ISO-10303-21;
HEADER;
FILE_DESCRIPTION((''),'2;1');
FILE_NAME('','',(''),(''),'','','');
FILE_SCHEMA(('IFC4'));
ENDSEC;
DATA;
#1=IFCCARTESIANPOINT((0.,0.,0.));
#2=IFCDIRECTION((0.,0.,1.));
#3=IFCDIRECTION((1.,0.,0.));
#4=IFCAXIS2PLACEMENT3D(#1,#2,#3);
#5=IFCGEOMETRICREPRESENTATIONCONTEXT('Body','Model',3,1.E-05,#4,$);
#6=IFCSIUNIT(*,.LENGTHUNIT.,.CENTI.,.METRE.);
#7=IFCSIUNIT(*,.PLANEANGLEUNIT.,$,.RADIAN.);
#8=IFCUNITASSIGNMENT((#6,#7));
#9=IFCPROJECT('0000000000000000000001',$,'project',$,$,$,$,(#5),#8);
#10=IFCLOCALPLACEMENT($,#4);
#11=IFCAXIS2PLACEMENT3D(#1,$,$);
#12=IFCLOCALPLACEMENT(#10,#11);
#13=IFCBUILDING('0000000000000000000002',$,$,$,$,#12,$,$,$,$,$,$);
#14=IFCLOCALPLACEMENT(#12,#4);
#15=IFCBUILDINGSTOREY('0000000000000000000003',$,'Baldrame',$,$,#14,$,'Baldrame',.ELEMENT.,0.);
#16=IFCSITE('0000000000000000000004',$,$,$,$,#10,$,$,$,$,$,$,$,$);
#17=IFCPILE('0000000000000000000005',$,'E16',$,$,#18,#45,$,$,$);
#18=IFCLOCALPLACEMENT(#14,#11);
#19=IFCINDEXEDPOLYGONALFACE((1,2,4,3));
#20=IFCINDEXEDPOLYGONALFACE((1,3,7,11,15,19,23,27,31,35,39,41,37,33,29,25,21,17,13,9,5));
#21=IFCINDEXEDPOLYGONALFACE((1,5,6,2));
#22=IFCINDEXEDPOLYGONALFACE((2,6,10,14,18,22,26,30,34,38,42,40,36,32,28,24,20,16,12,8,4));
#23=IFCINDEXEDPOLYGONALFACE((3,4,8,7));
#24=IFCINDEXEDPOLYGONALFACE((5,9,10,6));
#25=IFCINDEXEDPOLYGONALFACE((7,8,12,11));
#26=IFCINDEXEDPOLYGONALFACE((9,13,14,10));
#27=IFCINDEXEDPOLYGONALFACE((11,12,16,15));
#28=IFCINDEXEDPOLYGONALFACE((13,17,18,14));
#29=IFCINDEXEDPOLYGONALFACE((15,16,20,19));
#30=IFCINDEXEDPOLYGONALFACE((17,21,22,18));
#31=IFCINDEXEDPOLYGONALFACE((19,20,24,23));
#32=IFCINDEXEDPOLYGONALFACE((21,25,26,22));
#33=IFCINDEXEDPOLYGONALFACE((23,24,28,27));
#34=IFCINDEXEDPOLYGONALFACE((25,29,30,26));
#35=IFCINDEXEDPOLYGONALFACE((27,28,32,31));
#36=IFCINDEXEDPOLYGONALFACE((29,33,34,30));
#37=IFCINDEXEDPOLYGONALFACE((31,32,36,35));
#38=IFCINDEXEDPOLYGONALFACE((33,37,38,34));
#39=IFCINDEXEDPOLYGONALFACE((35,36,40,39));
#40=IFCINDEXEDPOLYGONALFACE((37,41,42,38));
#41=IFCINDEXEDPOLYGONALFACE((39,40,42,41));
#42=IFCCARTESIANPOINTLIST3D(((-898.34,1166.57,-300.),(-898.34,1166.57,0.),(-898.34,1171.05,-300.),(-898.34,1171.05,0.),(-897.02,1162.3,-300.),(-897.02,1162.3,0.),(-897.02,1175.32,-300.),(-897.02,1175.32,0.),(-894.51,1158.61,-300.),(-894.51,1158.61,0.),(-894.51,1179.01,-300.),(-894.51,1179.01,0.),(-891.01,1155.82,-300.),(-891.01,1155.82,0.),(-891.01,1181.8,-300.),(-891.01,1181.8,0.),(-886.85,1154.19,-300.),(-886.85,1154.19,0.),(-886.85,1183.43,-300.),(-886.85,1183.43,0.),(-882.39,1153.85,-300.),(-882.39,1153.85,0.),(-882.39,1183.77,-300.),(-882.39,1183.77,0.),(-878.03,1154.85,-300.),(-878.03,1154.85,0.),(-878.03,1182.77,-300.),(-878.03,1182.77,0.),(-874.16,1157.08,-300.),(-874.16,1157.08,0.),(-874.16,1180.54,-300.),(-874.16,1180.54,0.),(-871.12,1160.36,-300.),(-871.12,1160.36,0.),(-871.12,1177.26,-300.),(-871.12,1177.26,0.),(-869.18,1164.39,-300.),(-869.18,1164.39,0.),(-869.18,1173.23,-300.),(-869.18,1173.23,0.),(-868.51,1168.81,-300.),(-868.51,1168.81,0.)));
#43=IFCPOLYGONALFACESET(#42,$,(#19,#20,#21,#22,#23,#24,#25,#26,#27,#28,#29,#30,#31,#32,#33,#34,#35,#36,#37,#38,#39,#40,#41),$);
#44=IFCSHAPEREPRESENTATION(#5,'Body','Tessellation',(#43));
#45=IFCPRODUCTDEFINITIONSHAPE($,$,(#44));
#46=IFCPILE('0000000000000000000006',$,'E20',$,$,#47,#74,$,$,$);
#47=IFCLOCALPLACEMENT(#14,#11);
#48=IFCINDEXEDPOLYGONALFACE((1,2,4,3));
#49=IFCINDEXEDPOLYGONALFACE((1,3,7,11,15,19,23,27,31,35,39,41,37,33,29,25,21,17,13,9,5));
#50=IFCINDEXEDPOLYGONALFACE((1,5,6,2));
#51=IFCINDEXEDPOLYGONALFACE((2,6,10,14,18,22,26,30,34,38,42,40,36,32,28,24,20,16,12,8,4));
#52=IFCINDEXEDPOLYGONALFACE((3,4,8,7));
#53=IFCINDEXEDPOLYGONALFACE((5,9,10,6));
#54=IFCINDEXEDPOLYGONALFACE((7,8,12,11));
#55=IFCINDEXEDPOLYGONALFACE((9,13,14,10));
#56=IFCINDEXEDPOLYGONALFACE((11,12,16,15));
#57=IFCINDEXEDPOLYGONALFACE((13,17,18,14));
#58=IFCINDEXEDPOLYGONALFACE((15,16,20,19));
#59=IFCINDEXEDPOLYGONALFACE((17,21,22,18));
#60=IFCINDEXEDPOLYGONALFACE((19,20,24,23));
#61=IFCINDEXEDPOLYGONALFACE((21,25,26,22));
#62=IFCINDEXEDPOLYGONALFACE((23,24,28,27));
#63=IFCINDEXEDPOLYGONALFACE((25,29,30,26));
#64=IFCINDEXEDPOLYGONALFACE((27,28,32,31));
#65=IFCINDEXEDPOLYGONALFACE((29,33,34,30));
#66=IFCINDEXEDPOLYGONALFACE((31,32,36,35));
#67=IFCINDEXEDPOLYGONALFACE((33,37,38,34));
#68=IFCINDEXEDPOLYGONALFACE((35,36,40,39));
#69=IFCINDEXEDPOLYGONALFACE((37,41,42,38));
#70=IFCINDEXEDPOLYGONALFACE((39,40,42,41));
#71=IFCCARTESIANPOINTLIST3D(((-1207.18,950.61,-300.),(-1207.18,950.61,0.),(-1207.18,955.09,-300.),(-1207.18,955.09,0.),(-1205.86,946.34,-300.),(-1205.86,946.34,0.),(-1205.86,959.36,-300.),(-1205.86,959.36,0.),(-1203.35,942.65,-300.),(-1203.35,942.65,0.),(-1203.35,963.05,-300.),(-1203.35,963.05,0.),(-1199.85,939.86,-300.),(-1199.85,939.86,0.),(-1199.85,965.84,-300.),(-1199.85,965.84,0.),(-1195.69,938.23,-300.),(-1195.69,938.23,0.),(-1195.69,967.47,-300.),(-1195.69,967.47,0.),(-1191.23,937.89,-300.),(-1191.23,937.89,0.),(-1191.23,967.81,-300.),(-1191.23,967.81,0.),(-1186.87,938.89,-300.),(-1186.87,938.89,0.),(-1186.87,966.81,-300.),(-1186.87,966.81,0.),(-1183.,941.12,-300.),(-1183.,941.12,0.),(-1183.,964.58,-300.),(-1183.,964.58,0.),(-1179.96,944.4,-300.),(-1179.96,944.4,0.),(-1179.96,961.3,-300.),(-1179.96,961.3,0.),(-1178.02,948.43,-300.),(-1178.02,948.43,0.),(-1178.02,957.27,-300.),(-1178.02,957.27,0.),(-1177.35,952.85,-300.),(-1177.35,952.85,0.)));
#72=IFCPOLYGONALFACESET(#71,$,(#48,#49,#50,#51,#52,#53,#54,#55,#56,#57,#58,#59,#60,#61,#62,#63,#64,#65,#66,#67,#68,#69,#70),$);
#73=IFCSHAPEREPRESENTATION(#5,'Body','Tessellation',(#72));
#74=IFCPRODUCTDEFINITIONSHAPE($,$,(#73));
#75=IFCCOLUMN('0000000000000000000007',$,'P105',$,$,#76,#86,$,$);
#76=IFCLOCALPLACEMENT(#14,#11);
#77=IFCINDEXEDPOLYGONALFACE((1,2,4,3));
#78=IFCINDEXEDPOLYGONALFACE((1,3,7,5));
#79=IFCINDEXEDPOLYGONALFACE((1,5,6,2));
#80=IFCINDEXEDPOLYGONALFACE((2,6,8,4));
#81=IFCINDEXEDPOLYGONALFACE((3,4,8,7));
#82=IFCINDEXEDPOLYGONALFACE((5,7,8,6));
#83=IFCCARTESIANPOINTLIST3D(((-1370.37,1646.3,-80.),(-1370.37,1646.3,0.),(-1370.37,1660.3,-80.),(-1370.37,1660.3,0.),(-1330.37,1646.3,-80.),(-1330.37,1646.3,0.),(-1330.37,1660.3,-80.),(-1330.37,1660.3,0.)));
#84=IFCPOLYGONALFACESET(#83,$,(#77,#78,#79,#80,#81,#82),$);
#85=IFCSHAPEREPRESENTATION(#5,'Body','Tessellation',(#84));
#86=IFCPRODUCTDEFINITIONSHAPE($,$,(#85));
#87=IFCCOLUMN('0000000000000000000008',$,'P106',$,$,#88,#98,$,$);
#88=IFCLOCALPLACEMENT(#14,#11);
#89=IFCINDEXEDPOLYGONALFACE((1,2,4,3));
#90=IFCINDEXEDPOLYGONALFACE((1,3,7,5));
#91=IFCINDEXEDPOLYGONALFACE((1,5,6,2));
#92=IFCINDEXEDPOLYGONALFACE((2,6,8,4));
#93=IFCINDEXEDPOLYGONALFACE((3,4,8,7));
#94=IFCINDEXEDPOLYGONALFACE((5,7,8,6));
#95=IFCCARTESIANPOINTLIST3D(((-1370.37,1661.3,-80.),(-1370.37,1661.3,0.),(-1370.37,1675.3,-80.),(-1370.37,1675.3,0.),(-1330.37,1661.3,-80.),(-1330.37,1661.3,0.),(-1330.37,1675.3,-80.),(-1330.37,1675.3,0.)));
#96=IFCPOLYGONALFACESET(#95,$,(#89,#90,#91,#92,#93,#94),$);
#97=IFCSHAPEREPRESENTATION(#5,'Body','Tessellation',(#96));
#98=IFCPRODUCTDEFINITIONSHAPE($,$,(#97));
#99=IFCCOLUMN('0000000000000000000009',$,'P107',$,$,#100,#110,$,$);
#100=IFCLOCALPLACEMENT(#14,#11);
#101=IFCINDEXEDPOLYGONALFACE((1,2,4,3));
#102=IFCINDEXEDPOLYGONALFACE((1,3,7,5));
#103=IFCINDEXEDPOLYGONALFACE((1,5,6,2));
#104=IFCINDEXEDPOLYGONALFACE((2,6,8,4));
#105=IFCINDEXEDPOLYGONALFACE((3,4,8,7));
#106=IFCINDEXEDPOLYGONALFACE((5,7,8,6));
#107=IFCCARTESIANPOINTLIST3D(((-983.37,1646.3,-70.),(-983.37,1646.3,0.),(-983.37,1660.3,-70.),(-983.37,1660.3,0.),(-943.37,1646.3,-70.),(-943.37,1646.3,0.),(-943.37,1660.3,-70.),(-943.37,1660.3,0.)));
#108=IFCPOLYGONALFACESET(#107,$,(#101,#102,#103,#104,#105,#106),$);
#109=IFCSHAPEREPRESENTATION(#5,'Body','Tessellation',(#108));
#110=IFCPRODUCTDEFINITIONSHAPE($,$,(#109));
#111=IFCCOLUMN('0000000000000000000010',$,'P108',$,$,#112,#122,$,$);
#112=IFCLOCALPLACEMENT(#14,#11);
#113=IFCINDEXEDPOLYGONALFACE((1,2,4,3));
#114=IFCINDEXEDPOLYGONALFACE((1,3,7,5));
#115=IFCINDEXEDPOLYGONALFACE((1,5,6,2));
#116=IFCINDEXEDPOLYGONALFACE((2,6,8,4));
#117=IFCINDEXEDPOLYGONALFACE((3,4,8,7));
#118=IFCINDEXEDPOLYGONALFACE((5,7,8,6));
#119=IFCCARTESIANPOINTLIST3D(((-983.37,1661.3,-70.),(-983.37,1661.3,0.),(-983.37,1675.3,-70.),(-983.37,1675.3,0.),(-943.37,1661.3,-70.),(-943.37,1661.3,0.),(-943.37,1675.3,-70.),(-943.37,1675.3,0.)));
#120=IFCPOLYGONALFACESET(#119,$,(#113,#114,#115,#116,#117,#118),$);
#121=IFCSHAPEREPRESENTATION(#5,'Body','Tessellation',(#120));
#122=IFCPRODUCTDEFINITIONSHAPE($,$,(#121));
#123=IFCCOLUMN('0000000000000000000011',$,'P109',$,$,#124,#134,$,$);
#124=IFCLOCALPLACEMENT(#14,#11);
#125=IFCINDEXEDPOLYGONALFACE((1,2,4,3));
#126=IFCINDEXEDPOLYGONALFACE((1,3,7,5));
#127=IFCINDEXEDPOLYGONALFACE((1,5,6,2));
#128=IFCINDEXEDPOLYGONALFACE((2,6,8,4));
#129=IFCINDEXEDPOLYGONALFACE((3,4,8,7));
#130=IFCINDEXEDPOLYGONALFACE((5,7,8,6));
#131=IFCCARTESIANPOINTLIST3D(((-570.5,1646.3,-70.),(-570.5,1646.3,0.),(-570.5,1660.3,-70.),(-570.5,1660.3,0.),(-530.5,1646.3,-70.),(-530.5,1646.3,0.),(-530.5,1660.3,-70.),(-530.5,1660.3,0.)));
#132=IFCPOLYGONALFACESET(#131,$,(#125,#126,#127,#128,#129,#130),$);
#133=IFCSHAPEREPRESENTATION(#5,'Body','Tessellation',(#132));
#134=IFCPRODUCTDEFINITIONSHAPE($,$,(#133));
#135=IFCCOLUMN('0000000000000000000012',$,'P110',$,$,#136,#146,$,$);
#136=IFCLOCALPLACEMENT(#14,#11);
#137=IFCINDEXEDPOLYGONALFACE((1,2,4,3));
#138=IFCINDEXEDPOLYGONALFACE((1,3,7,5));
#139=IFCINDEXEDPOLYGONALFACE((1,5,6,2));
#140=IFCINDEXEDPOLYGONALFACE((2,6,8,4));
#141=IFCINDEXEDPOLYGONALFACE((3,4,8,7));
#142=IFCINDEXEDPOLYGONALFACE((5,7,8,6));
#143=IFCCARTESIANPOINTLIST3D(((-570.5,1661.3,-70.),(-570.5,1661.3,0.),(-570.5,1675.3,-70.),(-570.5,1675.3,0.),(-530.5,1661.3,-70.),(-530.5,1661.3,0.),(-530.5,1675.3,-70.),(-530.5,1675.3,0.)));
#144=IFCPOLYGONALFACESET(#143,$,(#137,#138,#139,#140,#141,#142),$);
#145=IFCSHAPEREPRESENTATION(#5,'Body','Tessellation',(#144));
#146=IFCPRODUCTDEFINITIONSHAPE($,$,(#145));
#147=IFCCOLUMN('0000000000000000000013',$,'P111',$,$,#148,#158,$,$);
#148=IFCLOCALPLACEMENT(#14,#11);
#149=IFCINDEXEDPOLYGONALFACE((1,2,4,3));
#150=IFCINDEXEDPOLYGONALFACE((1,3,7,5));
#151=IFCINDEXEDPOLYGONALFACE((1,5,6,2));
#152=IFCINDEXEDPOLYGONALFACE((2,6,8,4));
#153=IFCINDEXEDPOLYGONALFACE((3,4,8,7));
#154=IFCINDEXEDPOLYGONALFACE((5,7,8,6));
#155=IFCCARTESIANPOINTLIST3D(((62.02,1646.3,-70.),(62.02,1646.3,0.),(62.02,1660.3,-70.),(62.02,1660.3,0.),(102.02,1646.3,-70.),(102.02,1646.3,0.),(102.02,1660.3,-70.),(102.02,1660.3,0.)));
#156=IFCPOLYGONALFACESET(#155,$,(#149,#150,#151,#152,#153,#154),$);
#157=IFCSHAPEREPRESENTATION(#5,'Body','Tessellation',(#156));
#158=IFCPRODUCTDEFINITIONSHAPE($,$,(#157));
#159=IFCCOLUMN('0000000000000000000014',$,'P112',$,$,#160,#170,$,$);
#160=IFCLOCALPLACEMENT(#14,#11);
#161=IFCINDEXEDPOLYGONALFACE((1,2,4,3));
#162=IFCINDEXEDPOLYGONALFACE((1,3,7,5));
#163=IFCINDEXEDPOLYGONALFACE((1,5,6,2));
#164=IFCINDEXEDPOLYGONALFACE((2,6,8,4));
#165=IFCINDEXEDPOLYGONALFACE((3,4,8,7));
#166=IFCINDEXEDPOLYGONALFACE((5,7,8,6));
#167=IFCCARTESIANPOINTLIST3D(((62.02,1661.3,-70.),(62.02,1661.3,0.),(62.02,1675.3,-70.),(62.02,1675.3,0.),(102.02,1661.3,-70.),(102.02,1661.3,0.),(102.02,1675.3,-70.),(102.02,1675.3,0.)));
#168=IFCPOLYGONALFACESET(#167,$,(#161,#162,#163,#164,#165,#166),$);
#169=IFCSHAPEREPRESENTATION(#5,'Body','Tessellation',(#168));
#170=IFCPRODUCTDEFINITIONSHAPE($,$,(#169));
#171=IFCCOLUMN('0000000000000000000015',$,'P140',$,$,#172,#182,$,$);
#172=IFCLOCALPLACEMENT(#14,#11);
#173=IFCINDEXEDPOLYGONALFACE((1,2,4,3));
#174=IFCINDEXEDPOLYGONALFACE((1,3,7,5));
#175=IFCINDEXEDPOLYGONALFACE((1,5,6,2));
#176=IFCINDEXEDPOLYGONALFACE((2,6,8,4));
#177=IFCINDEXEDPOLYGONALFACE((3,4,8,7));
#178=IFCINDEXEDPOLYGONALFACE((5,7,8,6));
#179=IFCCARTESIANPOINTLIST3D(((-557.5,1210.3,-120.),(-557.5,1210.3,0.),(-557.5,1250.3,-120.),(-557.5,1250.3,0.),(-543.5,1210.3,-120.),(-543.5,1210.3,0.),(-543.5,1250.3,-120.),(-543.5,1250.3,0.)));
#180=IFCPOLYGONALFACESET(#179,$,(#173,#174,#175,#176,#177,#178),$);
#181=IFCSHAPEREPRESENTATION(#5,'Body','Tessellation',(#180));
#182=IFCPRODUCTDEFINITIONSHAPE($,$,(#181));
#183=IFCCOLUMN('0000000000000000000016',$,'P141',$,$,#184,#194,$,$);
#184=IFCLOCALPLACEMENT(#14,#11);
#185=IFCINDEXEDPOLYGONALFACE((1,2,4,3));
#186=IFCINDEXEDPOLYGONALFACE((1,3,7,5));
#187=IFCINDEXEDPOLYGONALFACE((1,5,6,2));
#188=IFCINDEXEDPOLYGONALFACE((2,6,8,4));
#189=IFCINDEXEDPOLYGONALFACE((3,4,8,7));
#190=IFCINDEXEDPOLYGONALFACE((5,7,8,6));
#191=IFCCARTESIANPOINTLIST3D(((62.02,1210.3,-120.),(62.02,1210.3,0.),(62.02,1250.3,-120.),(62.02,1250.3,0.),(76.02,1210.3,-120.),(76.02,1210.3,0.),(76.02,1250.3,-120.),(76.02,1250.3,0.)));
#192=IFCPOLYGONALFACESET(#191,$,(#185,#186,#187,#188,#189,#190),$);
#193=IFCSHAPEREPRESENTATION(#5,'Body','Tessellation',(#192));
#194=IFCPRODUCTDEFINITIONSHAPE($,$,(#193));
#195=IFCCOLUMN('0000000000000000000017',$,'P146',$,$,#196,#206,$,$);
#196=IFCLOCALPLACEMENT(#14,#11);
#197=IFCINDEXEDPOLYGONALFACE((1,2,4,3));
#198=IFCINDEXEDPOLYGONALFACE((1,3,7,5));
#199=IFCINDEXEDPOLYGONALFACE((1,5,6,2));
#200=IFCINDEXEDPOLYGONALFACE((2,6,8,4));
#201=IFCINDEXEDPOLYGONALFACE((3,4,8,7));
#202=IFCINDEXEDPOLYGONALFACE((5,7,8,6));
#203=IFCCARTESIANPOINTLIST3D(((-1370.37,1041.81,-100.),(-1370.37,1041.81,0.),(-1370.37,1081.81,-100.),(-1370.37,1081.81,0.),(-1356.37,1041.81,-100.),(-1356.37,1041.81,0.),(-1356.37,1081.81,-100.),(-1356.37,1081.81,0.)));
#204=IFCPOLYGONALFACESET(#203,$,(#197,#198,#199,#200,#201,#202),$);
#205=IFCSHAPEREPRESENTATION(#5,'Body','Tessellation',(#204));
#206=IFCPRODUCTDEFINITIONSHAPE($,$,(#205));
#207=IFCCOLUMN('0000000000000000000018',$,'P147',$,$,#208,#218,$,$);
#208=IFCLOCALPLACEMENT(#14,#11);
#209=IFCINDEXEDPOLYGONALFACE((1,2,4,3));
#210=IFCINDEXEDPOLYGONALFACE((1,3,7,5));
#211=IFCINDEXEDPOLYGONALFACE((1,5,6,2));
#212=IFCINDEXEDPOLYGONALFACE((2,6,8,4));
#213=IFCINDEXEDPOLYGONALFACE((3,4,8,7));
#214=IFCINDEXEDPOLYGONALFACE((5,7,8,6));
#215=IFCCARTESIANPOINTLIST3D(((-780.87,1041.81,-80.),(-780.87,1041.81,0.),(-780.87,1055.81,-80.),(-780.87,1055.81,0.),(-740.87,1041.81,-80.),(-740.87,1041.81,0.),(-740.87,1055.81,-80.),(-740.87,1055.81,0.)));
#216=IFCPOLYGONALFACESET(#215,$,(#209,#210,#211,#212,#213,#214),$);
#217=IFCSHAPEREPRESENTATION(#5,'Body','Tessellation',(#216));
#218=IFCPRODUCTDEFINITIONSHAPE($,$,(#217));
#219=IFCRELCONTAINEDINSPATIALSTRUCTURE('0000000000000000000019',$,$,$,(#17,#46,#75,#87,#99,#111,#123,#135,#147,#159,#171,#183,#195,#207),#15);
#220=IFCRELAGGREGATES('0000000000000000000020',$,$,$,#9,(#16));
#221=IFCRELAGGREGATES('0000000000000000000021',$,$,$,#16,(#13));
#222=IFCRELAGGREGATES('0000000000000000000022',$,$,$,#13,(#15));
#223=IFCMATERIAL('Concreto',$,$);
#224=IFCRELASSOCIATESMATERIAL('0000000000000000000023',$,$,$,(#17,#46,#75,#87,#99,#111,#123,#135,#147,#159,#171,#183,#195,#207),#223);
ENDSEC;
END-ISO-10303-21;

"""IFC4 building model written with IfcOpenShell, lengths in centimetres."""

from ifc_helpers import new_model, si_unit, frame, origin, origin_with_axes, origin_2d_with_axis, place, context, project, spatial, rectangle, circle, extrude, material, element, save


model = new_model("IFC4")

# Units and contexts
model_context = context("Model", 3, precision=1e-05, world=origin_with_axes(), identifier="Body")
ifc_project = project(units=[si_unit("LENGTHUNIT", "METRE", prefix="CENTI"), si_unit("PLANEANGLEUNIT", "RADIAN")], contexts=[model_context])

# Site, building, storey
site_placement = place(None, origin_with_axes())
site = spatial("IfcSite", under=ifc_project, at=site_placement)
building_placement = place(site_placement, origin())
building = spatial("IfcBuilding", under=site, at=building_placement)
storey_placement = place(building_placement, origin_with_axes())
storey = spatial("IfcBuildingStorey", under=building, at=storey_placement, Name="Baldrame", LongName="Baldrame", CompositionType="ELEMENT", Elevation=0.0)

# Piles
ifc_material = material(Name="Concreto")
for number, where, z_axis, x_axis, name in (
    (1, (-883.51, 1168.81, 0.0), (0.0, 0.0, 1.0), (1.0, 0.0, 0.0), "E16"),
    (2, (-1192.35, 952.85, 0.0), (0.0, 0.0, 1.0), (1.0, 0.0, 0.0), "E20"),
):
    element("IfcPile", number, at=place(storey_placement, frame(where, z_axis=z_axis, x_axis=x_axis)), inside=storey, material=ifc_material, Name=name, context=model_context, shape_type="SolidModel", body=[
        extrude(circle(Radius=15.0, at=origin_2d_with_axis()), frame((0.0, 0.0, -300.0), z_axis=(0.0, 0.0, 1.0), x_axis=(1.0, 0.0, 0.0)), (0.0, 0.0, 1.0), 300.0),
    ])

# Columns
for number, where, z_axis, x_axis, name in (
    (3, (-1350.37, 1653.3, 0.0), (0.0, 0.0, 1.0), (1.0, 0.0, 0.0), "P105"),
    (4, (-1350.37, 1668.3, 0.0), (0.0, 0.0, 1.0), (1.0, 0.0, 0.0), "P106"),
):
    element("IfcColumn", number, at=place(storey_placement, frame(where, z_axis=z_axis, x_axis=x_axis)), inside=storey, material=ifc_material, Name=name, context=model_context, shape_type="SolidModel", body=[
        extrude(rectangle(XDim=14.0, YDim=40.0, at=origin_2d_with_axis()), frame((0.0, 0.0, -80.0), z_axis=(0.0, 0.0, 1.0), x_axis=(0.0, -1.0, 0.0)), (0.0, 0.0, 1.0), 80.0),
    ])
for number, where, z_axis, x_axis, name in (
    (5, (-963.37, 1653.3, 0.0), (0.0, 0.0, 1.0), (1.0, 0.0, 0.0), "P107"),
    (6, (-963.37, 1668.3, 0.0), (0.0, 0.0, 1.0), (1.0, 0.0, 0.0), "P108"),
    (7, (-550.5, 1653.3, 0.0), (0.0, 0.0, 1.0), (1.0, 0.0, 0.0), "P109"),
    (8, (-550.5, 1668.3, 0.0), (0.0, 0.0, 1.0), (1.0, 0.0, 0.0), "P110"),
    (9, (82.02, 1653.3, 0.0), (0.0, 0.0, 1.0), (1.0, 0.0, 0.0), "P111"),
    (10, (82.02, 1668.3, 0.0), (0.0, 0.0, 1.0), (1.0, 0.0, 0.0), "P112"),
):
    element("IfcColumn", number, at=place(storey_placement, frame(where, z_axis=z_axis, x_axis=x_axis)), inside=storey, material=ifc_material, Name=name, context=model_context, shape_type="SolidModel", body=[
        extrude(rectangle(XDim=14.0, YDim=40.0, at=origin_2d_with_axis()), frame((0.0, 0.0, -70.0), z_axis=(0.0, 0.0, 1.0), x_axis=(0.0, -1.0, 0.0)), (0.0, 0.0, 1.0), 70.0),
    ])
for number, where, z_axis, x_axis, name in (
    (11, (-550.5, 1230.3, 0.0), (0.0, 0.0, 1.0), (1.0, 0.0, 0.0), "P140"),
    (12, (69.02, 1230.3, 0.0), (0.0, 0.0, 1.0), (1.0, 0.0, 0.0), "P141"),
):
    element("IfcColumn", number, at=place(storey_placement, frame(where, z_axis=z_axis, x_axis=x_axis)), inside=storey, material=ifc_material, Name=name, context=model_context, shape_type="SolidModel", body=[
        extrude(rectangle(XDim=14.0, YDim=40.0, at=origin_2d_with_axis()), frame((0.0, 0.0, -120.0), z_axis=(0.0, 0.0, 1.0), x_axis=(1.0, 0.0, 0.0)), (0.0, 0.0, 1.0), 120.0),
    ])
column_1_placement = place(storey_placement, frame((-1363.37, 1061.81, 0.0), z_axis=(0.0, 0.0, 1.0), x_axis=(1.0, 0.0, 0.0)))
element("IfcColumn", 13, at=column_1_placement, inside=storey, material=ifc_material, Name="P146", context=model_context, shape_type="SolidModel", body=[
    extrude(rectangle(XDim=14.0, YDim=40.0, at=origin_2d_with_axis()), frame((0.0, 0.0, -100.0), z_axis=(0.0, 0.0, 1.0), x_axis=(1.0, 0.0, 0.0)), (0.0, 0.0, 1.0), 100.0),
])
column_2_placement = place(storey_placement, frame((-760.87, 1048.81, 0.0), z_axis=(0.0, 0.0, 1.0), x_axis=(1.0, 0.0, 0.0)))
element("IfcColumn", 14, at=column_2_placement, inside=storey, material=ifc_material, Name="P147", context=model_context, shape_type="SolidModel", body=[
    extrude(rectangle(XDim=14.0, YDim=40.0, at=origin_2d_with_axis()), frame((0.0, 0.0, -80.0), z_axis=(0.0, 0.0, 1.0), x_axis=(0.0, 1.0, 0.0)), (0.0, 0.0, 1.0), 80.0),
])

save(model, "model.ifc")
